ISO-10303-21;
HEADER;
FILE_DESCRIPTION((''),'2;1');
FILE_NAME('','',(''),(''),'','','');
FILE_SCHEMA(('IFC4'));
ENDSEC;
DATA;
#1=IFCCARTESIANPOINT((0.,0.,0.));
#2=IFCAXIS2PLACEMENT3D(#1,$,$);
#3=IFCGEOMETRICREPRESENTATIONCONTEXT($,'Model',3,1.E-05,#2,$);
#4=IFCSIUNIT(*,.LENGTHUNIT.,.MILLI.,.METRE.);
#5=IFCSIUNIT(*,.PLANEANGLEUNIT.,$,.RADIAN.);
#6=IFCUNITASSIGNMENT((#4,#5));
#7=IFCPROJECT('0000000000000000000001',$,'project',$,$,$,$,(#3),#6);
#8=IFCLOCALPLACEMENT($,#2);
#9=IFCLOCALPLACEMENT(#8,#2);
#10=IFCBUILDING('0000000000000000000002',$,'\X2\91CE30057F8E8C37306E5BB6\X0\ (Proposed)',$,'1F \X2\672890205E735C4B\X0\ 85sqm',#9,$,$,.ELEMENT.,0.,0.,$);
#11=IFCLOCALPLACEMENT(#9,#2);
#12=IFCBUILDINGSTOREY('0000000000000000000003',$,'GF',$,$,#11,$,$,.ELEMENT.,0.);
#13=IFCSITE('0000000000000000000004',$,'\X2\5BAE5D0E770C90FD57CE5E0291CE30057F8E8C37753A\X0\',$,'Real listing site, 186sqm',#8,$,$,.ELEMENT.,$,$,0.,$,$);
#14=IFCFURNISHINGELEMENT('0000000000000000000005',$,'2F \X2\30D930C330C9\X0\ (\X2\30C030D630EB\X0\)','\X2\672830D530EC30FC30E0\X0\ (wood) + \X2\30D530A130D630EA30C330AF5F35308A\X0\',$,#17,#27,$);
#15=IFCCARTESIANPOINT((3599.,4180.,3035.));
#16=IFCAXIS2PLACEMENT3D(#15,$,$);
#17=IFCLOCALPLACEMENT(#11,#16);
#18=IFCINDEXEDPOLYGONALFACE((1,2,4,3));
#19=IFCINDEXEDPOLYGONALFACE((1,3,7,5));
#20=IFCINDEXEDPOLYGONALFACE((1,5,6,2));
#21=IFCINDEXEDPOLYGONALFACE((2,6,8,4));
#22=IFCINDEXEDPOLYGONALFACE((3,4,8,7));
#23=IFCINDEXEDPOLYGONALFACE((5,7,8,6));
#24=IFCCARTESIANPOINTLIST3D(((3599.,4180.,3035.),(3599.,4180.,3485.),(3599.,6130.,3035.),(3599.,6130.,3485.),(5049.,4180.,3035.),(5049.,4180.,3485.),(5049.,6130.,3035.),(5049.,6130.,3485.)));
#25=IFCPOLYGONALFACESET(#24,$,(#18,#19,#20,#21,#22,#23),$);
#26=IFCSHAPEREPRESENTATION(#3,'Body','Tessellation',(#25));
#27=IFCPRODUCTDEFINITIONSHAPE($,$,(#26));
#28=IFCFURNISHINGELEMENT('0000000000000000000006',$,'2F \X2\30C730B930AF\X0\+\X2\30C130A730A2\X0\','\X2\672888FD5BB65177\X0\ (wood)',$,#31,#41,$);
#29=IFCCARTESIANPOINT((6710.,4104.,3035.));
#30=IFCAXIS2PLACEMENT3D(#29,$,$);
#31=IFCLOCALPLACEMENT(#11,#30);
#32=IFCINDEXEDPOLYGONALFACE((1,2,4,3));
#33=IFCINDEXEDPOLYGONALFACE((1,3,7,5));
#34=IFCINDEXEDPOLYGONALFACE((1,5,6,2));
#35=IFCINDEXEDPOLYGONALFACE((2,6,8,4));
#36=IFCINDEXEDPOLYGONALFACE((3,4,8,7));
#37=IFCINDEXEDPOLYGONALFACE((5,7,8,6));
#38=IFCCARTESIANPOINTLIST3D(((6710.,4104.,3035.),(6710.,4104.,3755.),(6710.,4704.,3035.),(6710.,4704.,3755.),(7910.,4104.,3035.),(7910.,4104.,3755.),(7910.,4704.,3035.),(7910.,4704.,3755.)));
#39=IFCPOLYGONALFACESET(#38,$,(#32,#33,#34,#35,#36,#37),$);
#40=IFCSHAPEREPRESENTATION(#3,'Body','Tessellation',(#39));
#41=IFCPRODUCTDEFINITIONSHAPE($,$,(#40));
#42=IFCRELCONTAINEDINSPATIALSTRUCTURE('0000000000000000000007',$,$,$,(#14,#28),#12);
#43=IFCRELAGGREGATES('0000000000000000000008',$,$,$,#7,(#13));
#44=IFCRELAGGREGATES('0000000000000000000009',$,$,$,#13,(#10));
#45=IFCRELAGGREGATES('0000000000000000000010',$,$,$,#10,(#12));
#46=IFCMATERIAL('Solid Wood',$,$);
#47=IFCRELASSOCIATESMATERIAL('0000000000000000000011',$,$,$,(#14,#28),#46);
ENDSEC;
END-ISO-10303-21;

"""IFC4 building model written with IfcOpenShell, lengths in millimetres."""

from ifc_helpers import new_model, si_unit, frame, frame_2d, origin, place, context, project, spatial, rectangle, extrude, material, element, save


model = new_model("IFC4")

# Units and contexts
model_context = context("Model", 3, precision=1e-05, world=origin())
ifc_project = project(units=[si_unit("LENGTHUNIT", "METRE", prefix="MILLI"), si_unit("PLANEANGLEUNIT", "RADIAN")], contexts=[model_context])

# Site, building, storey
site_placement = place(None, origin())
site = spatial("IfcSite", under=ifc_project, at=site_placement, Name="宮崎県都城市野々美谷町", ObjectType="Real listing site, 186sqm", CompositionType="ELEMENT", RefElevation=0.0)
building_placement = place(site_placement, origin())
building = spatial("IfcBuilding", under=site, at=building_placement, Name="野々美谷の家 (Proposed)", ObjectType="1F 木造平屋 85sqm", CompositionType="ELEMENT", ElevationOfRefHeight=0.0, ElevationOfTerrain=0.0)
storey_placement = place(building_placement, origin())
storey = spatial("IfcBuildingStorey", under=building, at=storey_placement, Name="GF", CompositionType="ELEMENT", Elevation=0.0)

# Shared definitions
ifc_material_1 = material(Name="Solid Wood")

# Furnishing elements
furnishing_1_placement = place(storey_placement, frame((3599.0, 4180.0, 3035.0)))
element("IfcFurnishingElement", 1, at=furnishing_1_placement, inside=storey, material=ifc_material_1, Name="2F ベッド (ダブル)", Description="木フレーム (wood) + ファブリック張り", context=model_context, shape_type="SweptSolid", body=[
    extrude(rectangle(XDim=1450.0, YDim=1950.0, at=frame_2d((725.0, 975.0))), frame((3599.0, 4180.0, 3035.0)), (0.0, 0.0, 1.0), 450.0),
])
furnishing_2_placement = place(storey_placement, frame((6710.0, 4104.0, 3035.0)))
element("IfcFurnishingElement", 2, at=furnishing_2_placement, inside=storey, material=ifc_material_1, Name="2F デスク+チェア", Description="木製家具 (wood)", context=model_context, shape_type="SweptSolid", body=[
    extrude(rectangle(XDim=1200.0, YDim=600.0, at=frame_2d((600.0, 300.0))), frame((6710.0, 4104.0, 3035.0)), (0.0, 0.0, 1.0), 720.0),
])

save(model, "model.ifc")
